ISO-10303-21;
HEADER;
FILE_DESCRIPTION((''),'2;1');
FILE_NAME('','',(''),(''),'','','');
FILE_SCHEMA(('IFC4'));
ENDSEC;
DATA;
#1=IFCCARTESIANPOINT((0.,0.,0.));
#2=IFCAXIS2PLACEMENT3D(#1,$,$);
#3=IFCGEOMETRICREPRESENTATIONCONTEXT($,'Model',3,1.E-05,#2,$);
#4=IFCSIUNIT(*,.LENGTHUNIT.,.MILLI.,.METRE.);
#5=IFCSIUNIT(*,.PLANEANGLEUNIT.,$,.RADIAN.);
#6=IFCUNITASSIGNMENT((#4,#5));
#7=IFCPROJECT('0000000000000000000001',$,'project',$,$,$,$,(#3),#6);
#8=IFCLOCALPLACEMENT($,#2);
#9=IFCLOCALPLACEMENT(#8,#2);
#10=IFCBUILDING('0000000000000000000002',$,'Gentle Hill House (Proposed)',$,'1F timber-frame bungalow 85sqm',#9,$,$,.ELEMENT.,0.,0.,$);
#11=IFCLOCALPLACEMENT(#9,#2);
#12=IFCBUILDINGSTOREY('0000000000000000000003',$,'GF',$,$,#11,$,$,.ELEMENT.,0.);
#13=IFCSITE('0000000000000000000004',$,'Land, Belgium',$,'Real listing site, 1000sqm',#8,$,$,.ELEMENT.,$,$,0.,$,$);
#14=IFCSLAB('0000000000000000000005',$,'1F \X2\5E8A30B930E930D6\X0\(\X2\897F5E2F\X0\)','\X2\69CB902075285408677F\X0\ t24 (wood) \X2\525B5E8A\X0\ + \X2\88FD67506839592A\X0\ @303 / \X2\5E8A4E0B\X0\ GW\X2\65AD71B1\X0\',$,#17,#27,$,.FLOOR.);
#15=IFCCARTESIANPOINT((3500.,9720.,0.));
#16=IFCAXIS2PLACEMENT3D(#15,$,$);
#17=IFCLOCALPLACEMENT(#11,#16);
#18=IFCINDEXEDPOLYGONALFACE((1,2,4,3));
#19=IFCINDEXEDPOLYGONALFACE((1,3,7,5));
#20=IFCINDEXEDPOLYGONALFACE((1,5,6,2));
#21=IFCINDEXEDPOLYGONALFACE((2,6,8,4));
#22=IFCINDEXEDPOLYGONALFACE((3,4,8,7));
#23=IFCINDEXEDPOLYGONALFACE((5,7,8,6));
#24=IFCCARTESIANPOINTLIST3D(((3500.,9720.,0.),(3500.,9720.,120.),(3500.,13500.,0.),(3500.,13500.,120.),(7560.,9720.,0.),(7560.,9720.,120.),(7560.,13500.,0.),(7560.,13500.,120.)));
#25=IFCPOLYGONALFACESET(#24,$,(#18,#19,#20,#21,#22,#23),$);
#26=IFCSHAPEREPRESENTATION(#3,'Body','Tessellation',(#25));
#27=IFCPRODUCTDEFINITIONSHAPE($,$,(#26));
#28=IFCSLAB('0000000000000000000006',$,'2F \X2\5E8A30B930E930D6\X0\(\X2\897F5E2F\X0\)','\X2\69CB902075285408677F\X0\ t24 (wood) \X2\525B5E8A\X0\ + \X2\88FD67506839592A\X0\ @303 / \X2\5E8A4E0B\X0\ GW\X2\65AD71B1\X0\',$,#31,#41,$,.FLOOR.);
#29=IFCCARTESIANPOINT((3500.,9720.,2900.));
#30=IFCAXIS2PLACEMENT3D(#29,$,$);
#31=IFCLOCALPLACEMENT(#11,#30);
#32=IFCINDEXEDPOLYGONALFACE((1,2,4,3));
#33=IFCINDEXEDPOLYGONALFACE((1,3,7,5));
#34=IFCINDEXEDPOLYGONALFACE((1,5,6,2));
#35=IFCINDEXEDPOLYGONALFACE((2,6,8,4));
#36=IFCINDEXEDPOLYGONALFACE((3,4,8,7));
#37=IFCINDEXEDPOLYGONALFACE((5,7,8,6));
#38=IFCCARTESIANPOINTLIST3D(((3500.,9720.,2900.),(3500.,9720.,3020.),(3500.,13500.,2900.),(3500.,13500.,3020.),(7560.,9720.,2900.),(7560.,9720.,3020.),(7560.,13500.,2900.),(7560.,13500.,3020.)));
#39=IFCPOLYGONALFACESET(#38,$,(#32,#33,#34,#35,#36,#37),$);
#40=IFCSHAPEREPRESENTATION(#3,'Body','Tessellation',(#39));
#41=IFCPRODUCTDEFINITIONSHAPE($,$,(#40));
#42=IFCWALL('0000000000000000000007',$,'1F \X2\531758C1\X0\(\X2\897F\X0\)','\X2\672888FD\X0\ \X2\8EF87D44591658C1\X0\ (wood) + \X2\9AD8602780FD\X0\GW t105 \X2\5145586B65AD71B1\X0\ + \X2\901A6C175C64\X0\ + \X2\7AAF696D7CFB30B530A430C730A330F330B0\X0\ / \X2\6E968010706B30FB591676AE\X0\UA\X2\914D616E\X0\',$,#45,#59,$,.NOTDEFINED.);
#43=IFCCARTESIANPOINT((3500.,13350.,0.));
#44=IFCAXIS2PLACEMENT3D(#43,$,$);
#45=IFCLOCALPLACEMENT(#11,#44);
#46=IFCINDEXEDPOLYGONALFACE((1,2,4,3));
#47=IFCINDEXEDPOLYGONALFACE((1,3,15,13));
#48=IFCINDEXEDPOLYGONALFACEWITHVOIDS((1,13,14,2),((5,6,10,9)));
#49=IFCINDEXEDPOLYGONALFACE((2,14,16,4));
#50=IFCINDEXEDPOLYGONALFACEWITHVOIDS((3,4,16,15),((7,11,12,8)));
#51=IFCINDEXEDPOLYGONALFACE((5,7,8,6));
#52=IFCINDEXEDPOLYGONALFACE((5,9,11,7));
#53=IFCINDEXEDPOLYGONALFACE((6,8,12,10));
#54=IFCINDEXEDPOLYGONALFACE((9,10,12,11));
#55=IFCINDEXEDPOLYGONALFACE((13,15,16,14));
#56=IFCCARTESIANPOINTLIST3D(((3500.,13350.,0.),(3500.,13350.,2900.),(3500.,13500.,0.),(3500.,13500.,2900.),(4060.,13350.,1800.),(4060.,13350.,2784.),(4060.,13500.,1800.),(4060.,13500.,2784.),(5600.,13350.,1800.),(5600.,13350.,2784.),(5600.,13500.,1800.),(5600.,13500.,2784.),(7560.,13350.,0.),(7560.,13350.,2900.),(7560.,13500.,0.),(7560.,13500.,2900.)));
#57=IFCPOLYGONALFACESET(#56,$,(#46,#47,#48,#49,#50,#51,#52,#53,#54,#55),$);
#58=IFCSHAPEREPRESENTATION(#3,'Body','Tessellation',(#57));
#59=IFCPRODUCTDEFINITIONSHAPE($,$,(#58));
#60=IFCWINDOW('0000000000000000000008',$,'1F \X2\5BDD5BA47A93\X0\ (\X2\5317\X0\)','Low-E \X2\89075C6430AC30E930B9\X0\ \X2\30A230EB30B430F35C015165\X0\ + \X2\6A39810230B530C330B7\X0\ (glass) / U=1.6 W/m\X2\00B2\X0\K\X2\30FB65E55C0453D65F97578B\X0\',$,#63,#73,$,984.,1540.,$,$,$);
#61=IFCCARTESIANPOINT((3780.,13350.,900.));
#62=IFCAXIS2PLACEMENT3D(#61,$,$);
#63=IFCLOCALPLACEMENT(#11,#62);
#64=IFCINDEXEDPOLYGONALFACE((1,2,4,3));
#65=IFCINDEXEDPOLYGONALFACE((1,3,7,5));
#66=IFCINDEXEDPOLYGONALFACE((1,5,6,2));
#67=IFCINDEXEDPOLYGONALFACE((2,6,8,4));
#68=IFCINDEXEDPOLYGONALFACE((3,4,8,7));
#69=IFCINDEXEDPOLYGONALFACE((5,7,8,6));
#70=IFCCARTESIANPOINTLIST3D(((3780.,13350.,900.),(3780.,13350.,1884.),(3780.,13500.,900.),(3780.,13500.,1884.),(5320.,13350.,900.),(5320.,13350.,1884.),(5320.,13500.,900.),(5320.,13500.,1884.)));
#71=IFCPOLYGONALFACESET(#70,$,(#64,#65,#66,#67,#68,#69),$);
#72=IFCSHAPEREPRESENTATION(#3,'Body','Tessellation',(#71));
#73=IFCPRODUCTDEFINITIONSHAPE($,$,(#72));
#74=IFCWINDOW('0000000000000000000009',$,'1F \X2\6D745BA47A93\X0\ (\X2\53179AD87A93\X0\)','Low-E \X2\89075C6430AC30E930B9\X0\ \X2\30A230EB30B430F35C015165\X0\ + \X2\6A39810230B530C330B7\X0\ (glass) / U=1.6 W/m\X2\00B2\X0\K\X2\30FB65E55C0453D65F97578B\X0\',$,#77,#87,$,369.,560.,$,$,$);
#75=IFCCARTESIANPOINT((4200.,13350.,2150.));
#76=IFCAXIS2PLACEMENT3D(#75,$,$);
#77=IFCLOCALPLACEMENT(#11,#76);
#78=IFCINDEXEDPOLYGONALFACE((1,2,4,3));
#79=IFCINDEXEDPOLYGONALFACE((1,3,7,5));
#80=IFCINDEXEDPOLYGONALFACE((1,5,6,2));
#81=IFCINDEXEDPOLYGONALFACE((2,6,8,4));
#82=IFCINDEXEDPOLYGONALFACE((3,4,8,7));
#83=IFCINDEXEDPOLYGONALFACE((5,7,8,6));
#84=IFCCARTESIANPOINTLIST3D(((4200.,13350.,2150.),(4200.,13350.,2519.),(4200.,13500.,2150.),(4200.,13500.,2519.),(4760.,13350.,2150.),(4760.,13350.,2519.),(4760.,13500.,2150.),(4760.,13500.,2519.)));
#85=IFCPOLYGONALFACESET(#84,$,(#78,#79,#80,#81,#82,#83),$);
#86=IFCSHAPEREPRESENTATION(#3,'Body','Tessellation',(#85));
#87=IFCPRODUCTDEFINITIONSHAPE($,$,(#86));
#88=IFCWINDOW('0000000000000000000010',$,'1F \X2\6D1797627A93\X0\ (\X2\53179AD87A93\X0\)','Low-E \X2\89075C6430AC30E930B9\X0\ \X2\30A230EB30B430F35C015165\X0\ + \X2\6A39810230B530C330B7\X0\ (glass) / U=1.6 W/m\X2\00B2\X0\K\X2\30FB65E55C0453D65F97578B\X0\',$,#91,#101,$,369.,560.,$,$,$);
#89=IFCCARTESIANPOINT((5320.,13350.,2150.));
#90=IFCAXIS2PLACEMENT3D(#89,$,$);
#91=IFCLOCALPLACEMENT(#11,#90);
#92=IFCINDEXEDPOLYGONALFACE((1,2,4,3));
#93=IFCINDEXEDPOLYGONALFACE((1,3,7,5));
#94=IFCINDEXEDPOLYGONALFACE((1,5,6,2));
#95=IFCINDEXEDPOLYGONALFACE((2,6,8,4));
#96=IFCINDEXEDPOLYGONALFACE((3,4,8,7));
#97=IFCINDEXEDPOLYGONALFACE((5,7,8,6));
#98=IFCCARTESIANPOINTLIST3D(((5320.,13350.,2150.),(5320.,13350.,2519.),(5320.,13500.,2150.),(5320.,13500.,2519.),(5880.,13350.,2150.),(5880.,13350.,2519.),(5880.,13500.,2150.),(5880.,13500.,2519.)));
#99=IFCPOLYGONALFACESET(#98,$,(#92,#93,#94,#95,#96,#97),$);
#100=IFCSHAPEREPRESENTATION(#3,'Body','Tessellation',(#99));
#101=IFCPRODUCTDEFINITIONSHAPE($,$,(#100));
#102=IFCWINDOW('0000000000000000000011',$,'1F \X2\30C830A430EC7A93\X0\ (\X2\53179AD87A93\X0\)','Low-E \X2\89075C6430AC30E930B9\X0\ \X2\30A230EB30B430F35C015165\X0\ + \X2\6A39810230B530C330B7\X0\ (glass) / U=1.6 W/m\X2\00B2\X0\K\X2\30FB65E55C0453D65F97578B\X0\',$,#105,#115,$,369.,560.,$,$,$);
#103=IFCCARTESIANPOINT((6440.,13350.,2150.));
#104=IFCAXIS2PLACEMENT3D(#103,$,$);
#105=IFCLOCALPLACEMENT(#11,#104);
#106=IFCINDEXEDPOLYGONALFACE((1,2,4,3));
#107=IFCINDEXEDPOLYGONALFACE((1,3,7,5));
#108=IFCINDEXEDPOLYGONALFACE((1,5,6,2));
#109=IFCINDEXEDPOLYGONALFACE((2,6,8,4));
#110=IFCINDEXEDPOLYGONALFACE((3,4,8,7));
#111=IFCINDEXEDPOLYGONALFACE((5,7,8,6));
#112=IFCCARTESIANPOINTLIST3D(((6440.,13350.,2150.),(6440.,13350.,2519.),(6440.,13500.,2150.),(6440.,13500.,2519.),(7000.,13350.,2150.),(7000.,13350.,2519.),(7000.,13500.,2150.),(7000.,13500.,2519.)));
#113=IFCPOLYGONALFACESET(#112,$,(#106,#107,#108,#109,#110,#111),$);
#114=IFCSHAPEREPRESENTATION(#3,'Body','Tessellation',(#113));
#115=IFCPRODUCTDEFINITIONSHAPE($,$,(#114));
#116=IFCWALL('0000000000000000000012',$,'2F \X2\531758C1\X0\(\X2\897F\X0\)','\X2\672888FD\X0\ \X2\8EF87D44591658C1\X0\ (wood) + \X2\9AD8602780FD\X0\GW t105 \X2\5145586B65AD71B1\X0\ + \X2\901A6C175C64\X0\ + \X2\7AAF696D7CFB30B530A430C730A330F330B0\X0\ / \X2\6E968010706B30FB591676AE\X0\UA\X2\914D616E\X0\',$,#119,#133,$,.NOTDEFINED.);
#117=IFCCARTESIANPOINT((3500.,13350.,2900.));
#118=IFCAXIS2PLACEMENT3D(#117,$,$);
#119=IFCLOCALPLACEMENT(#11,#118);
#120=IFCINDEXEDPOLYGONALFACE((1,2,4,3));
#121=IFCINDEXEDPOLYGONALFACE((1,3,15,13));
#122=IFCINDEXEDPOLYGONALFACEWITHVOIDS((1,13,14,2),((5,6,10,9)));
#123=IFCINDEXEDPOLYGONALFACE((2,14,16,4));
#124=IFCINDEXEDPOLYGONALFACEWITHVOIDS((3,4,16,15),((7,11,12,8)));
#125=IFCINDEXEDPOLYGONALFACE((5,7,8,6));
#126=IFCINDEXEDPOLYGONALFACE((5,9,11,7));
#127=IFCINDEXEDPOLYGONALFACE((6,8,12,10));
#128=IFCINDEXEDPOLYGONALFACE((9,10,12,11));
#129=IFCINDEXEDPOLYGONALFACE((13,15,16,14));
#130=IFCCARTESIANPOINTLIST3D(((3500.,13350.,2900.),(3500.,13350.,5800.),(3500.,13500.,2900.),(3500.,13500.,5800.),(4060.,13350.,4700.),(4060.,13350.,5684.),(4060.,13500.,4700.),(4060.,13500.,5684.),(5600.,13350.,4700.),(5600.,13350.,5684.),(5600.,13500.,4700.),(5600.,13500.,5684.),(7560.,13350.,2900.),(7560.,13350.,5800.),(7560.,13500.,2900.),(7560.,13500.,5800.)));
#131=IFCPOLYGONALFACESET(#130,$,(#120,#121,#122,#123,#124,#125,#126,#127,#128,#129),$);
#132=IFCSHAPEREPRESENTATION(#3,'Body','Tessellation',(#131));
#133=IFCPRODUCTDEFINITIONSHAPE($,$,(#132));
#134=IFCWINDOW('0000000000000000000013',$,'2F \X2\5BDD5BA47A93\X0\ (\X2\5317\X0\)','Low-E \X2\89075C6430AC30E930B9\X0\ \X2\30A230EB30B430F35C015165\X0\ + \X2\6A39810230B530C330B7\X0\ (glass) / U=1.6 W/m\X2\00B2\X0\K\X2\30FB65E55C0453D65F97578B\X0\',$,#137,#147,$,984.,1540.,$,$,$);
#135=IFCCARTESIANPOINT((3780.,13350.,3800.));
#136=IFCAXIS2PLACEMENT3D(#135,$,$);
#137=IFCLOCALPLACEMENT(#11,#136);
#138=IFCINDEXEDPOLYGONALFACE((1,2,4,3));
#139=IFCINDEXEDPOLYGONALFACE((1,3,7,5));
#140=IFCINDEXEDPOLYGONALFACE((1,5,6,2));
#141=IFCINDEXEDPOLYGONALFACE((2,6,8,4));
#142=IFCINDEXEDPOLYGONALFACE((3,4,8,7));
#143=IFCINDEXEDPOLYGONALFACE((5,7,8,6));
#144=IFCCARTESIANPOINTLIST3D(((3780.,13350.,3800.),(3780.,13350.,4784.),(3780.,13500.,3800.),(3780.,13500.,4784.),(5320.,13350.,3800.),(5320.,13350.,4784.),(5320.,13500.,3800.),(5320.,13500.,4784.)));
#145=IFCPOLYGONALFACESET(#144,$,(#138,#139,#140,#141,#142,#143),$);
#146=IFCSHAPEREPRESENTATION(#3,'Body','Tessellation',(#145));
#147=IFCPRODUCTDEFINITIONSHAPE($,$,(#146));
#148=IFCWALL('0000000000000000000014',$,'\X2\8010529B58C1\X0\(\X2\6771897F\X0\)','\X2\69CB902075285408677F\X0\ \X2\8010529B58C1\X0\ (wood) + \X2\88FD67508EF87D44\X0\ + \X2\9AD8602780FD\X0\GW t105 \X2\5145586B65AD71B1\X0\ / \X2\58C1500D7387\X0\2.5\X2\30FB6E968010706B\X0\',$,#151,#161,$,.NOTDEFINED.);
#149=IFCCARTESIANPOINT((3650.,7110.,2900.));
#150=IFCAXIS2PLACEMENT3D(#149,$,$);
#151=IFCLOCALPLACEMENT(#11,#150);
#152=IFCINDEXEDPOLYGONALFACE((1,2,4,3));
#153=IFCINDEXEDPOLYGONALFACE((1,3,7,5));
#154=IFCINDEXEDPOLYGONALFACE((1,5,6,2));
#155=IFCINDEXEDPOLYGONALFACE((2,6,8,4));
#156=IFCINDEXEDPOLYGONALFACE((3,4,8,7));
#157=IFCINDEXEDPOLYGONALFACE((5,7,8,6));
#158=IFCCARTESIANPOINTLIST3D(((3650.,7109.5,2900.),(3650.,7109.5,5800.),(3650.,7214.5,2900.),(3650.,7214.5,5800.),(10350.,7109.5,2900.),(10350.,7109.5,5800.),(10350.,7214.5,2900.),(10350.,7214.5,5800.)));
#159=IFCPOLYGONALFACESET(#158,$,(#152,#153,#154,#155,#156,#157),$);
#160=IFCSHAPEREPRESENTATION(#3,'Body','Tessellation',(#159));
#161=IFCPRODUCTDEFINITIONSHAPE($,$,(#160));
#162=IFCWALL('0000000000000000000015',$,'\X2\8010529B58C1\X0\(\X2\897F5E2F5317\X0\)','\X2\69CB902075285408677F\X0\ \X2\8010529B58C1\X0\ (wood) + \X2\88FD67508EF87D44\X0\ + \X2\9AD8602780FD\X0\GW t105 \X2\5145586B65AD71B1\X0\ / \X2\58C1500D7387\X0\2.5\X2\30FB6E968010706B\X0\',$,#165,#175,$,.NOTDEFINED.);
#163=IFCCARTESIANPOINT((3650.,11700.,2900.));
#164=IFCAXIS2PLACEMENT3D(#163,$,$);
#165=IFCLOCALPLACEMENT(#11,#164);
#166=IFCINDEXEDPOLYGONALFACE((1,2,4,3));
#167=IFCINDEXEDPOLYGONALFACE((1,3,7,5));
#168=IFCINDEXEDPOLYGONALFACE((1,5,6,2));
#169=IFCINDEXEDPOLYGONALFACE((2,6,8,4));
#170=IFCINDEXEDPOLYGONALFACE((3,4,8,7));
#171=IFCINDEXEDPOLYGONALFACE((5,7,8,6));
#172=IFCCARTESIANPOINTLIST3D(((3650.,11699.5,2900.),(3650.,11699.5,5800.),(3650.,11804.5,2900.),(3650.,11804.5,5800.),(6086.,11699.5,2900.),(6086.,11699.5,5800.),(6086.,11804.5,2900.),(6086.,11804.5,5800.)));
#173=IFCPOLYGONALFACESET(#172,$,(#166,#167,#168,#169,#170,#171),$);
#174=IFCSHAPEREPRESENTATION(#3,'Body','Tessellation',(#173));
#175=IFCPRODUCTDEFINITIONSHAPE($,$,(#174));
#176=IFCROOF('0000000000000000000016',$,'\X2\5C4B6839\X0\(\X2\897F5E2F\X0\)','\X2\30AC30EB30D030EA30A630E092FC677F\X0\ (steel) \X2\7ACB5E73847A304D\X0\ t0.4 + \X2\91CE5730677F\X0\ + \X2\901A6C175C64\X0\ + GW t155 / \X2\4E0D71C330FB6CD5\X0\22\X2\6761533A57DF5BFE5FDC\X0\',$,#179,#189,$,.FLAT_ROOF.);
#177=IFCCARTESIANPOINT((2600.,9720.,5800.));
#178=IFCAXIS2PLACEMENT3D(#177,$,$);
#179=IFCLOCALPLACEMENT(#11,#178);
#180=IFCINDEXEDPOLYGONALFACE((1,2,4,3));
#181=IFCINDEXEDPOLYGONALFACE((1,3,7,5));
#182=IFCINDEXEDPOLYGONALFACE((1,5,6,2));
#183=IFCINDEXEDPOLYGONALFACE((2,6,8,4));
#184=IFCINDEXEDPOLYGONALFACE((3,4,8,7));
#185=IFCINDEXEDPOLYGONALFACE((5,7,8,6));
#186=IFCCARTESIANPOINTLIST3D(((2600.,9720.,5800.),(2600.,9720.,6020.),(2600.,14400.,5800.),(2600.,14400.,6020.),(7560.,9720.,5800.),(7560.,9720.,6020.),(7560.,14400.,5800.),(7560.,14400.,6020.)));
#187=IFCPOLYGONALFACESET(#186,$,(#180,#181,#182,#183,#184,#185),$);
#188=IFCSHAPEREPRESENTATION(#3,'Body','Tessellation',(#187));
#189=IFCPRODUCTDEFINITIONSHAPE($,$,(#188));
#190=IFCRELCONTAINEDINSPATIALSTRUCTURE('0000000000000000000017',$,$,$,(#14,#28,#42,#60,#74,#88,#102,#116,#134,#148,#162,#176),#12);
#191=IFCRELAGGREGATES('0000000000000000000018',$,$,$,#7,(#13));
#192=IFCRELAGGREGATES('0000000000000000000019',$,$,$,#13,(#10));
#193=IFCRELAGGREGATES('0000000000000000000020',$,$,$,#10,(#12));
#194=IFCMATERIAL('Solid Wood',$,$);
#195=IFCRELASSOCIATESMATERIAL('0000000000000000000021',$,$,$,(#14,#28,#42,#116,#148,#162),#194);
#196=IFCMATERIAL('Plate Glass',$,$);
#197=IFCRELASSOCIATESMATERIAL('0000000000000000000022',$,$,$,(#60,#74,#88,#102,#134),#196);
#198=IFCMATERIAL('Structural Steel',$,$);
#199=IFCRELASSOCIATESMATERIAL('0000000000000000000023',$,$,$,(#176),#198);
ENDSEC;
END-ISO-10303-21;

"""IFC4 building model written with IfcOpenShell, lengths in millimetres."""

from ifc_helpers import new_model, si_unit, frame, frame_2d, origin, place, context, project, spatial, rectangle, extrude, material, element, fill, save


model = new_model("IFC4")

# Units and contexts
model_context = context("Model", 3, precision=1e-05, world=origin())
ifc_project = project(units=[si_unit("LENGTHUNIT", "METRE", prefix="MILLI"), si_unit("PLANEANGLEUNIT", "RADIAN")], contexts=[model_context])

# Site, building, storey
site_placement = place(None, origin())
site = spatial("IfcSite", under=ifc_project, at=site_placement, Name="Land, Belgium", ObjectType="Real listing site, 1000sqm", CompositionType="ELEMENT", RefElevation=0.0)
building_placement = place(site_placement, origin())
building = spatial("IfcBuilding", under=site, at=building_placement, Name="Gentle Hill House (Proposed)", ObjectType="1F timber-frame bungalow 85sqm", CompositionType="ELEMENT", ElevationOfRefHeight=0.0, ElevationOfTerrain=0.0)
storey_placement = place(building_placement, origin())
storey = spatial("IfcBuildingStorey", under=building, at=storey_placement, Name="GF", CompositionType="ELEMENT", Elevation=0.0)

# Slabs
ifc_material_1 = material(Name="Solid Wood")
slab_1_placement = place(storey_placement, frame((3500.0, 9720.0, 0.0)))
element("IfcSlab", 1, at=slab_1_placement, inside=storey, material=ifc_material_1, Name="1F 床スラブ(西帯)", Description="構造用合板 t24 (wood) 剛床 + 製材根太 @303 / 床下 GW断熱", PredefinedType="FLOOR", context=model_context, shape_type="SweptSolid", body=[
    extrude(rectangle(XDim=4060.0, YDim=3780.0, at=frame_2d((2030.0, 1890.0))), frame((3500.0, 9720.0, 0.0)), (0.0, 0.0, 1.0), 120.0),
])
slab_2_placement = place(storey_placement, frame((3500.0, 9720.0, 2900.0)))
element("IfcSlab", 2, at=slab_2_placement, inside=storey, material=ifc_material_1, Name="2F 床スラブ(西帯)", Description="構造用合板 t24 (wood) 剛床 + 製材根太 @303 / 床下 GW断熱", PredefinedType="FLOOR", context=model_context, shape_type="SweptSolid", body=[
    extrude(rectangle(XDim=4060.0, YDim=3780.0, at=frame_2d((2030.0, 1890.0))), frame((3500.0, 9720.0, 2900.0)), (0.0, 0.0, 1.0), 120.0),
])

# Wall, openings, windows
wall_1_placement = place(storey_placement, frame((3500.0, 13350.0, 0.0)))
wall_1 = element("IfcWall", 3, at=wall_1_placement, inside=storey, material=ifc_material_1, Name="1F 北壁(西)", Description="木製 軸組外壁 (wood) + 高性能GW t105 充填断熱 + 通気層 + 窯業系サイディング / 準耐火・外皮UA配慮", PredefinedType="NOTDEFINED", context=model_context, shape_type="SweptSolid", body=[
    extrude(rectangle(XDim=4060.0, YDim=150.0, at=frame_2d((2030.0, 75.0))), frame((3500.0, 13350.0, 0.0)), (0.0, 0.0, 1.0), 2900.0),
])
opening_1_placement = place(storey_placement, frame((3780.0, 13350.0, 900.0)))
opening_1 = element("IfcOpeningElement", 4, at=opening_1_placement, cuts=wall_1, PredefinedType="NOTDEFINED", context=model_context, shape_type="SweptSolid", body=[
    extrude(rectangle(XDim=1540.0, YDim=150.0, at=frame_2d((770.0, 75.0))), frame((3780.0, 13350.0, 900.0)), (0.0, 0.0, 1.0), 984.0),
])
opening_2_placement = place(storey_placement, frame((4200.0, 13350.0, 2150.0)))
opening_2 = element("IfcOpeningElement", 5, at=opening_2_placement, cuts=wall_1, PredefinedType="NOTDEFINED", context=model_context, shape_type="SweptSolid", body=[
    extrude(rectangle(XDim=560.0, YDim=150.0, at=frame_2d((280.0, 75.0))), frame((4200.0, 13350.0, 2150.0)), (0.0, 0.0, 1.0), 369.0),
])
opening_3_placement = place(storey_placement, frame((5320.0, 13350.0, 2150.0)))
opening_3 = element("IfcOpeningElement", 6, at=opening_3_placement, cuts=wall_1, PredefinedType="NOTDEFINED", context=model_context, shape_type="SweptSolid", body=[
    extrude(rectangle(XDim=560.0, YDim=150.0, at=frame_2d((280.0, 75.0))), frame((5320.0, 13350.0, 2150.0)), (0.0, 0.0, 1.0), 369.0),
])
opening_4_placement = place(storey_placement, frame((6440.0, 13350.0, 2150.0)))
opening_4 = element("IfcOpeningElement", 7, at=opening_4_placement, cuts=wall_1, PredefinedType="NOTDEFINED", context=model_context, shape_type="SweptSolid", body=[
    extrude(rectangle(XDim=560.0, YDim=150.0, at=frame_2d((280.0, 75.0))), frame((6440.0, 13350.0, 2150.0)), (0.0, 0.0, 1.0), 369.0),
])
ifc_material_2 = material(Name="Plate Glass")
window_1_placement = place(storey_placement, frame((3780.0, 13350.0, 900.0)))
window_1 = element("IfcWindow", 8, at=window_1_placement, inside=storey, material=ifc_material_2, Name="1F 寝室窓 (北)", Description="Low-E 複層ガラス アルゴン封入 + 樹脂サッシ (glass) / U=1.6 W/m²K・日射取得型", OverallHeight=984.0, OverallWidth=1540.0, context=model_context, shape_type="SweptSolid", body=[
    extrude(rectangle(XDim=1540.0, YDim=150.0, at=frame_2d((770.0, 75.0))), frame((3780.0, 13350.0, 900.0)), (0.0, 0.0, 1.0), 984.0),
])
fill(opening_1, window_1)
window_2_placement = place(storey_placement, frame((4200.0, 13350.0, 2150.0)))
window_2 = element("IfcWindow", 9, at=window_2_placement, inside=storey, material=ifc_material_2, Name="1F 浴室窓 (北高窓)", Description="Low-E 複層ガラス アルゴン封入 + 樹脂サッシ (glass) / U=1.6 W/m²K・日射取得型", OverallHeight=369.0, OverallWidth=560.0, context=model_context, shape_type="SweptSolid", body=[
    extrude(rectangle(XDim=560.0, YDim=150.0, at=frame_2d((280.0, 75.0))), frame((4200.0, 13350.0, 2150.0)), (0.0, 0.0, 1.0), 369.0),
])
fill(opening_2, window_2)
window_3_placement = place(storey_placement, frame((5320.0, 13350.0, 2150.0)))
window_3 = element("IfcWindow", 10, at=window_3_placement, inside=storey, material=ifc_material_2, Name="1F 洗面窓 (北高窓)", Description="Low-E 複層ガラス アルゴン封入 + 樹脂サッシ (glass) / U=1.6 W/m²K・日射取得型", OverallHeight=369.0, OverallWidth=560.0, context=model_context, shape_type="SweptSolid", body=[
    extrude(rectangle(XDim=560.0, YDim=150.0, at=frame_2d((280.0, 75.0))), frame((5320.0, 13350.0, 2150.0)), (0.0, 0.0, 1.0), 369.0),
])
fill(opening_3, window_3)
window_4_placement = place(storey_placement, frame((6440.0, 13350.0, 2150.0)))
window_4 = element("IfcWindow", 11, at=window_4_placement, inside=storey, material=ifc_material_2, Name="1F トイレ窓 (北高窓)", Description="Low-E 複層ガラス アルゴン封入 + 樹脂サッシ (glass) / U=1.6 W/m²K・日射取得型", OverallHeight=369.0, OverallWidth=560.0, context=model_context, shape_type="SweptSolid", body=[
    extrude(rectangle(XDim=560.0, YDim=150.0, at=frame_2d((280.0, 75.0))), frame((6440.0, 13350.0, 2150.0)), (0.0, 0.0, 1.0), 369.0),
])
fill(opening_4, window_4)

# Wall, opening, window
wall_2_placement = place(storey_placement, frame((3500.0, 13350.0, 2900.0)))
wall_2 = element("IfcWall", 12, at=wall_2_placement, inside=storey, material=ifc_material_1, Name="2F 北壁(西)", Description="木製 軸組外壁 (wood) + 高性能GW t105 充填断熱 + 通気層 + 窯業系サイディング / 準耐火・外皮UA配慮", PredefinedType="NOTDEFINED", context=model_context, shape_type="SweptSolid", body=[
    extrude(rectangle(XDim=4060.0, YDim=150.0, at=frame_2d((2030.0, 75.0))), frame((3500.0, 13350.0, 2900.0)), (0.0, 0.0, 1.0), 2900.0),
])
opening_5_placement = place(storey_placement, frame((3780.0, 13350.0, 3800.0)))
opening_5 = element("IfcOpeningElement", 13, at=opening_5_placement, cuts=wall_2, PredefinedType="NOTDEFINED", context=model_context, shape_type="SweptSolid", body=[
    extrude(rectangle(XDim=1540.0, YDim=150.0, at=frame_2d((770.0, 75.0))), frame((3780.0, 13350.0, 3800.0)), (0.0, 0.0, 1.0), 984.0),
])
window_5_placement = place(storey_placement, frame((3780.0, 13350.0, 3800.0)))
window_5 = element("IfcWindow", 14, at=window_5_placement, inside=storey, material=ifc_material_2, Name="2F 寝室窓 (北)", Description="Low-E 複層ガラス アルゴン封入 + 樹脂サッシ (glass) / U=1.6 W/m²K・日射取得型", OverallHeight=984.0, OverallWidth=1540.0, context=model_context, shape_type="SweptSolid", body=[
    extrude(rectangle(XDim=1540.0, YDim=150.0, at=frame_2d((770.0, 75.0))), frame((3780.0, 13350.0, 3800.0)), (0.0, 0.0, 1.0), 984.0),
])
fill(opening_5, window_5)

# Walls
wall_3_placement = place(storey_placement, frame((3650.0, 7110.0, 2900.0)))
element("IfcWall", 15, at=wall_3_placement, inside=storey, material=ifc_material_1, Name="耐力壁(東西)", Description="構造用合板 耐力壁 (wood) + 製材軸組 + 高性能GW t105 充填断熱 / 壁倍率2.5・準耐火", PredefinedType="NOTDEFINED", context=model_context, shape_type="SweptSolid", body=[
    extrude(rectangle(XDim=6700.0, YDim=105.0, at=frame_2d((3350.0, 52.0))), frame((3650.0, 7110.0, 2900.0)), (0.0, 0.0, 1.0), 2900.0),
])
wall_4_placement = place(storey_placement, frame((3650.0, 11700.0, 2900.0)))
element("IfcWall", 16, at=wall_4_placement, inside=storey, material=ifc_material_1, Name="耐力壁(西帯北)", Description="構造用合板 耐力壁 (wood) + 製材軸組 + 高性能GW t105 充填断熱 / 壁倍率2.5・準耐火", PredefinedType="NOTDEFINED", context=model_context, shape_type="SweptSolid", body=[
    extrude(rectangle(XDim=2436.0, YDim=105.0, at=frame_2d((1218.0, 52.0))), frame((3650.0, 11700.0, 2900.0)), (0.0, 0.0, 1.0), 2900.0),
])

# Roof
ifc_material_3 = material(Name="Structural Steel")
for number, where, name in (
    (17, (2600.0, 9720.0, 5800.0), "屋根(西帯)"),
):
    element("IfcRoof", number, at=place(storey_placement, frame(where)), inside=storey, material=ifc_material_3, Name=name, Description="ガルバリウム鋼板 (steel) 立平葺き t0.4 + 野地板 + 通気層 + GW t155 / 不燃・法22条区域対応", PredefinedType="FLAT_ROOF", context=model_context, shape_type="SweptSolid", body=[
        extrude(rectangle(XDim=4960.0, YDim=4680.0, at=frame_2d((2480.0, 2340.0))), frame((2600.0, 9720.0, 5800.0)), (0.0, 0.0, 1.0), 220.0),
    ])

save(model, "model.ifc")
